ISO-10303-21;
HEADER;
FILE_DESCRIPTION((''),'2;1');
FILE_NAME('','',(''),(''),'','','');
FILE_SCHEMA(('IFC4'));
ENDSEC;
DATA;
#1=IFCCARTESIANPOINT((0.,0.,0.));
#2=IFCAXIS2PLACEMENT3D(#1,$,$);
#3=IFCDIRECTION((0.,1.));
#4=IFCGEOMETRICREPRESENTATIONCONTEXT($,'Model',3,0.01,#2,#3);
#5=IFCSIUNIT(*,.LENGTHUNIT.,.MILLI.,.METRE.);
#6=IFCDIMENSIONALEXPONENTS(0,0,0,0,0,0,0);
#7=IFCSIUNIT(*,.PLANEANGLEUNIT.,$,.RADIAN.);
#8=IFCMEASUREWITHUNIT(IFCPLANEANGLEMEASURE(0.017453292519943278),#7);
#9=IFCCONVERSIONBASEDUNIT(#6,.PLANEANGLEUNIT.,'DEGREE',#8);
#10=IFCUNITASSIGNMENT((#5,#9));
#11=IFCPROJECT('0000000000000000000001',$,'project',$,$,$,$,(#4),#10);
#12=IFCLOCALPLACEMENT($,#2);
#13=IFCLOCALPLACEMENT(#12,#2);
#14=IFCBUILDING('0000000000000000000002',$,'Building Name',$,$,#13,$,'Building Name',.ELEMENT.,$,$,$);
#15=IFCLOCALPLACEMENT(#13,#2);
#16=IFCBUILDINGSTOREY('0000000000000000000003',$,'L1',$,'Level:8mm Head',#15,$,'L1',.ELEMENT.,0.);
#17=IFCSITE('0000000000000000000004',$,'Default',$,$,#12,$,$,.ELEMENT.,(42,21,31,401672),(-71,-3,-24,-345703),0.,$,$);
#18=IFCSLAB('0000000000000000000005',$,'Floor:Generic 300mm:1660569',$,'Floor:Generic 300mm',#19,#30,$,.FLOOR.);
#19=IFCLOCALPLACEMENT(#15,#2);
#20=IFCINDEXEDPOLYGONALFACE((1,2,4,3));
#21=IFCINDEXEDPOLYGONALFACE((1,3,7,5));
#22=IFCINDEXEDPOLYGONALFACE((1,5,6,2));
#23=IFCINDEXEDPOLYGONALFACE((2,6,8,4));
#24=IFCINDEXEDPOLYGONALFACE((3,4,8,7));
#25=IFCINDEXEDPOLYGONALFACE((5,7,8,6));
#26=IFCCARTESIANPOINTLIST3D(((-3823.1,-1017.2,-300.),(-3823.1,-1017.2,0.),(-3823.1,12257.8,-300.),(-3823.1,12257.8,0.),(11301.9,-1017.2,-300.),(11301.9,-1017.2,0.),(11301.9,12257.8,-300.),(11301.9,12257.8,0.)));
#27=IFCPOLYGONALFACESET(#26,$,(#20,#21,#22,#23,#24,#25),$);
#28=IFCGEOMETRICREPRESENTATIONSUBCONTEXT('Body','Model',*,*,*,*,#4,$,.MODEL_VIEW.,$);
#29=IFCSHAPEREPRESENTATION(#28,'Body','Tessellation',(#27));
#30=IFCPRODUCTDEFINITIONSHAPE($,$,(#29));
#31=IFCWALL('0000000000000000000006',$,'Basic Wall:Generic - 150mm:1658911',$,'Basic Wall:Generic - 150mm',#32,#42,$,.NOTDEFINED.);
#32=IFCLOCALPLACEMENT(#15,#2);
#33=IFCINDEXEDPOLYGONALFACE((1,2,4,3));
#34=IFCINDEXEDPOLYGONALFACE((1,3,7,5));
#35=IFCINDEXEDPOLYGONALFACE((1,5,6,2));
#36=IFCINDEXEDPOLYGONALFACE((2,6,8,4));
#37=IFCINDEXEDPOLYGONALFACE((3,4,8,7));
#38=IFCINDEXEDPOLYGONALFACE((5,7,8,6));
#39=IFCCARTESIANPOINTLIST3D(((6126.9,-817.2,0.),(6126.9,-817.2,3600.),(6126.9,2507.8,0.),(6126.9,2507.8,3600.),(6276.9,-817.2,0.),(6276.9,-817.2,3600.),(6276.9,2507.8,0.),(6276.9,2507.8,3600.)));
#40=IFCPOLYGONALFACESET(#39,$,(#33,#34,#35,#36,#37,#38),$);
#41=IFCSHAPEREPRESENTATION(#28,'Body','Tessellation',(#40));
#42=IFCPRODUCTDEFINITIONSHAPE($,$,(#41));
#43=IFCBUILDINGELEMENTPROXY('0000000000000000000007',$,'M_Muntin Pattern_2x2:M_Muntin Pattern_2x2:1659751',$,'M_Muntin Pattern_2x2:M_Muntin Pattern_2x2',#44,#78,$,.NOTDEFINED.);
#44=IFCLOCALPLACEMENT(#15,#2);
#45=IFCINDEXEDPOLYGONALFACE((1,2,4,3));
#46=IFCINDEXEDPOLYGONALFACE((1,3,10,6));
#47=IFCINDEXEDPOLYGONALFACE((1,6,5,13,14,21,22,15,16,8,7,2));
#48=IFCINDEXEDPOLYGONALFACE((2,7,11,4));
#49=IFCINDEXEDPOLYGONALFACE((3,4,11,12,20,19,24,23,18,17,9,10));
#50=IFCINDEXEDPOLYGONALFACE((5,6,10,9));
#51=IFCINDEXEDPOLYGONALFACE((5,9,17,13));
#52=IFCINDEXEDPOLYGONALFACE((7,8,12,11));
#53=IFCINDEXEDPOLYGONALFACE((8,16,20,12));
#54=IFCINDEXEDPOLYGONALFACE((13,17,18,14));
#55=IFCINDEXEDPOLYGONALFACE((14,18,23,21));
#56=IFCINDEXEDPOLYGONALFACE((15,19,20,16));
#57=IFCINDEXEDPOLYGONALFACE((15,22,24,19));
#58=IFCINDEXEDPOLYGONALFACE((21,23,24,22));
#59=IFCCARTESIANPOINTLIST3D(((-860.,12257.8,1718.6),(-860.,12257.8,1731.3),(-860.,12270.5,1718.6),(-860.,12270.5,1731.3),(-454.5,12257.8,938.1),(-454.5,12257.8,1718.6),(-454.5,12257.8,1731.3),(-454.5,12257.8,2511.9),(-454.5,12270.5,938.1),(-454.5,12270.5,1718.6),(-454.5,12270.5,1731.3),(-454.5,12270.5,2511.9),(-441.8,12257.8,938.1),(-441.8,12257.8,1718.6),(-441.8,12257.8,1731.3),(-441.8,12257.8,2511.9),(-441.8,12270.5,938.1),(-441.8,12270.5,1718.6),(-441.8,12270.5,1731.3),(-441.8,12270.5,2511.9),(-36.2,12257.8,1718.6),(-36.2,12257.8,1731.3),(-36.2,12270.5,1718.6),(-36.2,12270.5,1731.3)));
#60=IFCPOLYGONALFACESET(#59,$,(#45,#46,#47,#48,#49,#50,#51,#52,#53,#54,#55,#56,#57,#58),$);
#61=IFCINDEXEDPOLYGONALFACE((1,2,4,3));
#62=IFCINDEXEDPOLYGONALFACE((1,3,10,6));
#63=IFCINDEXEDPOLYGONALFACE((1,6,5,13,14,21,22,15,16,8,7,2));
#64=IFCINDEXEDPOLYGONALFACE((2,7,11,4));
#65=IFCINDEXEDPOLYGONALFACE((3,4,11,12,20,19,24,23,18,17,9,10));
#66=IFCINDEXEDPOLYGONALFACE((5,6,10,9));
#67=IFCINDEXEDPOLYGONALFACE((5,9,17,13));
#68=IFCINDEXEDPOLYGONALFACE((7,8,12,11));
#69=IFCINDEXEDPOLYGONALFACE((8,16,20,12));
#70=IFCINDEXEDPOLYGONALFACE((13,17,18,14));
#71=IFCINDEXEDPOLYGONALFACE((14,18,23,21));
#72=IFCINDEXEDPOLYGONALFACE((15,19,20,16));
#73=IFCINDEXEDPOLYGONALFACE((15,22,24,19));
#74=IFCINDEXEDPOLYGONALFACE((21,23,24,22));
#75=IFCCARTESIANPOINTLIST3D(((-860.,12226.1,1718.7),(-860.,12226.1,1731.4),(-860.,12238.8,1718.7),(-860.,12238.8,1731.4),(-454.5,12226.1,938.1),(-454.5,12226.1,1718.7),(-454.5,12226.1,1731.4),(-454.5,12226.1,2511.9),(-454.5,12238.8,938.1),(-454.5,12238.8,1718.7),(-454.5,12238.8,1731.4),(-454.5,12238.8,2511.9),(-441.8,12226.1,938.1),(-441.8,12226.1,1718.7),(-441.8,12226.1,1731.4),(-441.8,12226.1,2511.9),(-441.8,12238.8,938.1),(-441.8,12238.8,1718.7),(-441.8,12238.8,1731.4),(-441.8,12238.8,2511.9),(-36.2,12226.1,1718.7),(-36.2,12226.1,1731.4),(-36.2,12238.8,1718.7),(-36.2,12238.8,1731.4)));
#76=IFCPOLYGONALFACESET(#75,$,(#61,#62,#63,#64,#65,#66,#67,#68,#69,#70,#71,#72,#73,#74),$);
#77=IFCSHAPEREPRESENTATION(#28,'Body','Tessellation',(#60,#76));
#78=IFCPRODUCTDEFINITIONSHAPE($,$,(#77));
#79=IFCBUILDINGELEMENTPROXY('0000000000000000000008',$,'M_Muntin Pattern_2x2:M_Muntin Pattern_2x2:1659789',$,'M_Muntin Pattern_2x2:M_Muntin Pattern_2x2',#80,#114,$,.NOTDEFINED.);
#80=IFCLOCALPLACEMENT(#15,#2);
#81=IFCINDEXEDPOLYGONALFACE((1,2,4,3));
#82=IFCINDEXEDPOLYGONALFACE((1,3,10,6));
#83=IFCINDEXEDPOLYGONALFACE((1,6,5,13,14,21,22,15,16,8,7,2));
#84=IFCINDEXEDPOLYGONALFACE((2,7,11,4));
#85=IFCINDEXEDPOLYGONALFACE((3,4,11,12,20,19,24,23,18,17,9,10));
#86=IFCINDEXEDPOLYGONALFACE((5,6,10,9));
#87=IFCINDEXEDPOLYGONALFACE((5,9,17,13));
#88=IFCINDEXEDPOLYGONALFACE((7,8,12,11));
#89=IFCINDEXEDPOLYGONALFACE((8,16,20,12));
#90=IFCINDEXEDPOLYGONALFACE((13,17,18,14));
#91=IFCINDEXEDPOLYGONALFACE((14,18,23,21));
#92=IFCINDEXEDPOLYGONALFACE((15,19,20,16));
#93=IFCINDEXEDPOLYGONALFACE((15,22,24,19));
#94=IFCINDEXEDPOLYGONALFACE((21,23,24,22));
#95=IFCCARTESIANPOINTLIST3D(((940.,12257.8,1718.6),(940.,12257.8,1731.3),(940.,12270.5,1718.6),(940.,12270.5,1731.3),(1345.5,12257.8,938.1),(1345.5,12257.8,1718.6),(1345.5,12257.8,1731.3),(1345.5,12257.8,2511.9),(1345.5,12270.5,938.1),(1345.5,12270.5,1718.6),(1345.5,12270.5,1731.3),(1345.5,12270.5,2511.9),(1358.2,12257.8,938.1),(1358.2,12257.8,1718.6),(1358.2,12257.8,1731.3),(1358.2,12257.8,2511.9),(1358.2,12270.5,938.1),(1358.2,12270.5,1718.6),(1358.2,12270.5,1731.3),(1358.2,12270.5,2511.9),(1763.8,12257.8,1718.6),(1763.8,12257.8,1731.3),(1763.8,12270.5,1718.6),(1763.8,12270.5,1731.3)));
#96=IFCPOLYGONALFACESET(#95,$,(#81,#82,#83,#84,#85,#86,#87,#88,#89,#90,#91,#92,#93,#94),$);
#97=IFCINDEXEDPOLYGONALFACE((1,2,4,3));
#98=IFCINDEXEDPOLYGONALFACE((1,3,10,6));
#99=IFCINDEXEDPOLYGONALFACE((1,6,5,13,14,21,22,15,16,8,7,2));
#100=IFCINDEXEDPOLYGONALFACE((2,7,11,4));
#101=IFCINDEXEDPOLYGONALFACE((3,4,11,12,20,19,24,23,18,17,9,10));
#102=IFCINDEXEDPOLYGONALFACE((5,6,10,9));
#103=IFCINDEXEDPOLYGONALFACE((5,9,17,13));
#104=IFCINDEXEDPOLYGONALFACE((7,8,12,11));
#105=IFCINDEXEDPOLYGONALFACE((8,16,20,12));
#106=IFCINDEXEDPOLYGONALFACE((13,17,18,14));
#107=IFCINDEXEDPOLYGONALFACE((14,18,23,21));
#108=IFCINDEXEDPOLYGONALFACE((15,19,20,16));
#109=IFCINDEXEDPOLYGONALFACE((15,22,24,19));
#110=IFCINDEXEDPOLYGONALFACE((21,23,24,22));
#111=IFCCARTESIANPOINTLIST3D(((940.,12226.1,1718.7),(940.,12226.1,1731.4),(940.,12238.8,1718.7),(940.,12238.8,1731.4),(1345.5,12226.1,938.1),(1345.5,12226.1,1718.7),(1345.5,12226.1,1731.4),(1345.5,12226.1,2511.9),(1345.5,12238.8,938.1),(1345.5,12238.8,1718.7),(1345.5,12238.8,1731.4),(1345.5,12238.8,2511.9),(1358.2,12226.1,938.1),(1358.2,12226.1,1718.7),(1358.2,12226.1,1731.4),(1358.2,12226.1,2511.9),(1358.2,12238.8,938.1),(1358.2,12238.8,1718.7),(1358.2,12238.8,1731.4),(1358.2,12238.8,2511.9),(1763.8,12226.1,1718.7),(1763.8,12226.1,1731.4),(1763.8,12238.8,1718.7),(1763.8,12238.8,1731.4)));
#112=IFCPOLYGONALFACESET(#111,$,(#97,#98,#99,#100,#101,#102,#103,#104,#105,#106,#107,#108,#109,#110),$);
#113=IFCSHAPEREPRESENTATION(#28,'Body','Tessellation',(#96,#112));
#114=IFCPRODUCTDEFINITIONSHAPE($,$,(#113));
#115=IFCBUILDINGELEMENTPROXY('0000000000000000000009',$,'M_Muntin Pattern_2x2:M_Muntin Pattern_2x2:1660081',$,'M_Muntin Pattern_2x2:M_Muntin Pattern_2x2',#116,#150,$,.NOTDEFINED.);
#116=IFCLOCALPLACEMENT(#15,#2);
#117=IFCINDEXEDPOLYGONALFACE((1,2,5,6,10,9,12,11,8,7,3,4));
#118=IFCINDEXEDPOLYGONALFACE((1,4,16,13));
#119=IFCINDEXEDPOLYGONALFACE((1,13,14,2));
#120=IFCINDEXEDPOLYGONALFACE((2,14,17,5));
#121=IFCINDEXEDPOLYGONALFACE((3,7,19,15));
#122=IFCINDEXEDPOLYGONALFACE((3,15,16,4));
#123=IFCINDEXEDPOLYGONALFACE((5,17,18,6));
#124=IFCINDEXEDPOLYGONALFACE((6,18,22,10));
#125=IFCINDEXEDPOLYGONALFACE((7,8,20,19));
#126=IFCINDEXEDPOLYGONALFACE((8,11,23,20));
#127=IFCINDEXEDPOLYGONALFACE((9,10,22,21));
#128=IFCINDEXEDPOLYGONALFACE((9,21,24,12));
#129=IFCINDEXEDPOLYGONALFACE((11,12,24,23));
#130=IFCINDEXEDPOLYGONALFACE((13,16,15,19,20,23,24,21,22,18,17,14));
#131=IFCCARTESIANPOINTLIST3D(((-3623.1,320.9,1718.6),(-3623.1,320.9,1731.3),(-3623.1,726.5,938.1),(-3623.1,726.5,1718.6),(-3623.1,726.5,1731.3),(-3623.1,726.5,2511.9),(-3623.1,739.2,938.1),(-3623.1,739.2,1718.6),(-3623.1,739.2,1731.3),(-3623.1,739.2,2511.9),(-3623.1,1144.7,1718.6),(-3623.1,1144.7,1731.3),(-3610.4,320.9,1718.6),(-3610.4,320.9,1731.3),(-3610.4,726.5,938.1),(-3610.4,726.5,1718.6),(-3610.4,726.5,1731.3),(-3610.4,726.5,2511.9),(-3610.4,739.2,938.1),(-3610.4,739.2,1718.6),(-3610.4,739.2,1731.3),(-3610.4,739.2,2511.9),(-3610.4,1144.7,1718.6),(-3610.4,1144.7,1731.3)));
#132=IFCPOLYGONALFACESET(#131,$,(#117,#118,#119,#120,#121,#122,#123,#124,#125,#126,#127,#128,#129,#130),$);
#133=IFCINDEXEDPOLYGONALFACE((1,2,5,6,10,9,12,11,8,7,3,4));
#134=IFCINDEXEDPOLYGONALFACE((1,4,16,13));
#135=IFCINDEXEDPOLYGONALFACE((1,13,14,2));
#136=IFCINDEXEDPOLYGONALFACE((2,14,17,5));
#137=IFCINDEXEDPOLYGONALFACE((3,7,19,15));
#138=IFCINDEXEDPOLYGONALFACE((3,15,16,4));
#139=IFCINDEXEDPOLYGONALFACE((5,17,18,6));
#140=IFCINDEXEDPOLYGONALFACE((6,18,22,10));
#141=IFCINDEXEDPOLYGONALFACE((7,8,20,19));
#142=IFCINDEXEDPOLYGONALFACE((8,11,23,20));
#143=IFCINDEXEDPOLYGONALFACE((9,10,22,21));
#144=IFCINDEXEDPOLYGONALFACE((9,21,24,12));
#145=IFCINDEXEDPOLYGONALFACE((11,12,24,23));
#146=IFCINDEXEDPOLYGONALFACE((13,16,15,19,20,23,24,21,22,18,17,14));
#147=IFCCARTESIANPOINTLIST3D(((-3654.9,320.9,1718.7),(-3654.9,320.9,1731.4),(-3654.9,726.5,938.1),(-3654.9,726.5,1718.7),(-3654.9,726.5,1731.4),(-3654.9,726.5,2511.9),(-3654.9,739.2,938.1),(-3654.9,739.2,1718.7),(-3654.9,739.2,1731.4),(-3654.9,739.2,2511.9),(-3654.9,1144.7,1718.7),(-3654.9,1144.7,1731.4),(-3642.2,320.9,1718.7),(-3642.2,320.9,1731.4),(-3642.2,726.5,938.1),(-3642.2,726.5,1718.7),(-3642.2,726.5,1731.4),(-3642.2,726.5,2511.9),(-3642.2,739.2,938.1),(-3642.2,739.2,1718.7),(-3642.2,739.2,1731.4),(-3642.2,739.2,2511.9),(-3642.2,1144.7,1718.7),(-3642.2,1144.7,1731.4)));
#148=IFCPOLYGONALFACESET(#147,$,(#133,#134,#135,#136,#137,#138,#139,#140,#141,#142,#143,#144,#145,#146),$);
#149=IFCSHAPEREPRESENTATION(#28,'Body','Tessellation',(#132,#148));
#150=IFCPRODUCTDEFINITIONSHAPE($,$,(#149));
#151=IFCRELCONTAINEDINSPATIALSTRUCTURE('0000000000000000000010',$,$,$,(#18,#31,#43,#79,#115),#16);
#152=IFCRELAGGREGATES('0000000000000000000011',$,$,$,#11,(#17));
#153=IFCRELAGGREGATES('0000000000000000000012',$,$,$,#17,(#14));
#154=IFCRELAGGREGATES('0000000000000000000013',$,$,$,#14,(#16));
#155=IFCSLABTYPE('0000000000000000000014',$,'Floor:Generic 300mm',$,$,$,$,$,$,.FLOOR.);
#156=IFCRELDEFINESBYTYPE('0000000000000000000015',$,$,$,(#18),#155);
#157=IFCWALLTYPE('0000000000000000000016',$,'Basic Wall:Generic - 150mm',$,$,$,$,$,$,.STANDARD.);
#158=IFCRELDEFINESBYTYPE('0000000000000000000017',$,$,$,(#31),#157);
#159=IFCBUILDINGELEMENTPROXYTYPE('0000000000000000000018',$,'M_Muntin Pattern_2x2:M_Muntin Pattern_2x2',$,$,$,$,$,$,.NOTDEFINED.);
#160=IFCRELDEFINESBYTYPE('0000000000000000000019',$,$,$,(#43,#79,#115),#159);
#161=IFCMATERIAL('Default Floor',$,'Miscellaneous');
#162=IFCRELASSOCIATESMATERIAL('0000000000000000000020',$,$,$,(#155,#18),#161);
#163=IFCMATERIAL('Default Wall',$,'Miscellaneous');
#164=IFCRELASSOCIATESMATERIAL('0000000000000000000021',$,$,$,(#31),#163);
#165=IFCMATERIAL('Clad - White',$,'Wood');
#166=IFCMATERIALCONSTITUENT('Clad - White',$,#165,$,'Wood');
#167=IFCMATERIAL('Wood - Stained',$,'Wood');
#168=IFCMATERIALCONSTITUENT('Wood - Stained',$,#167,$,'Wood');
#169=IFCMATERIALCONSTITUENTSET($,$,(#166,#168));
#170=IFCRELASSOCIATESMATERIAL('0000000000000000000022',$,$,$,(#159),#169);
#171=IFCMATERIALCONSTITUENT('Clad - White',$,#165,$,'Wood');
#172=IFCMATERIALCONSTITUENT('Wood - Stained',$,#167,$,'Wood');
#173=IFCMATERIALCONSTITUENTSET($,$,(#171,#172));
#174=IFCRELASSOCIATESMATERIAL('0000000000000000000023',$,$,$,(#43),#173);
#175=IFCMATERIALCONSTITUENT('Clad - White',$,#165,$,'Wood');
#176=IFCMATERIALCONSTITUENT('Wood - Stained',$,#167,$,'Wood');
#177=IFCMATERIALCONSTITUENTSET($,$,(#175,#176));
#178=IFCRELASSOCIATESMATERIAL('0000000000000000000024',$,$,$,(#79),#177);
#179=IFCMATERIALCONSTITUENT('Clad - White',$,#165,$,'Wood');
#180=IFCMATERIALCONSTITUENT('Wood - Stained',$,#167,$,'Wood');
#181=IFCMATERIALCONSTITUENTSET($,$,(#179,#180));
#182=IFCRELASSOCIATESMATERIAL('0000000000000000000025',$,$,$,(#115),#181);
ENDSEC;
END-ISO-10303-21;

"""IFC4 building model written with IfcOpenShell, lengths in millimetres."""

from ifc_helpers import new_model, entity, si_unit, converted_unit, direction, frame, origin, place, context, subcontext, project, spatial, indexed_curve, outline, extrude, source, transform, mapped, material, constituent, constituent_set, type_object, type_shapes, element, save


model = new_model("IFC4")

# Units and contexts
model_context = context("Model", 3, precision=0.01, world=origin(), true_north=direction((0.0, 1.0)))
body_context = subcontext(model_context, "Body", "Model", "MODEL_VIEW")
ifc_project = project(units=[si_unit("LENGTHUNIT", "METRE", prefix="MILLI"), converted_unit("PLANEANGLEUNIT", "DEGREE", entity("IfcPlaneAngleMeasure", 0.017453292519943278), si_unit("PLANEANGLEUNIT", "RADIAN"), dimensions=[0, 0, 0, 0, 0, 0, 0])], contexts=[model_context])

# Site, building, storey
site_placement = place(None, origin())
site = spatial("IfcSite", under=ifc_project, at=site_placement, Name="Default", CompositionType="ELEMENT", RefLatitude=(42, 21, 31, 401672), RefLongitude=(-71, -3, -24, -345703), RefElevation=0.0)
building_placement = place(site_placement, origin())
building = spatial("IfcBuilding", under=site, at=building_placement, Name="Building Name", LongName="Building Name", CompositionType="ELEMENT")
storey_placement = place(building_placement, origin())
storey = spatial("IfcBuildingStorey", under=building, at=storey_placement, Name="L1", ObjectType="Level:8mm Head", LongName="L1", CompositionType="ELEMENT", Elevation=0.0)

# Slab
ifc_material_1 = material(Name="Default Floor", Category="Miscellaneous")
slab_type = type_object("IfcSlabType", Name="Floor:Generic 300mm", PredefinedType="FLOOR", material=ifc_material_1)
slab_placement = place(storey_placement, origin())
element("IfcSlab", 1, at=slab_placement, inside=storey, type_object=slab_type, material=ifc_material_1, Name="Floor:Generic 300mm:1660569", ObjectType="Floor:Generic 300mm", PredefinedType="FLOOR", context=body_context, shape_type="SweptSolid", body=[
    extrude(outline(indexed_curve([(-6637.5, -7562.5), (6637.5, -7562.5), (6637.5, 7562.5), (-6637.5, 7562.5), (-6637.5, -7562.5)], self_intersect=False)), frame((3739.4, 5620.3, 0.0), z_axis=(0.0, 0.0, -1.0), x_axis=(0.0, 1.0, 0.0)), (0.0, 0.0, 1.0), 300.0),
])

# Wall
ifc_material_2 = material(Name="Default Wall", Category="Miscellaneous")
wall_type = type_object("IfcWallType", Name="Basic Wall:Generic - 150mm", PredefinedType="STANDARD")
wall_placement = place(storey_placement, frame((6201.9, 2507.8, 0.0), z_axis=(0.0, 0.0, 1.0), x_axis=(0.0, -1.0, 0.0)))
element("IfcWall", 2, at=wall_placement, inside=storey, type_object=wall_type, material=ifc_material_2, Name="Basic Wall:Generic - 150mm:1658911", ObjectType="Basic Wall:Generic - 150mm", PredefinedType="NOTDEFINED", context=body_context, shape_type="SweptSolid", body=[
    extrude(outline(indexed_curve([(3325.0, 75.0), (0.0, 75.0), (0.0, -75.0), (3325.0, -75.0), (3325.0, 75.0)], self_intersect=False)), origin(), (0.0, 0.0, 1.0), 3600.0),
])

# Building element proxies
ifc_material_3 = material(Name="Clad - White", Category="Wood")
ifc_constituent_1 = constituent(ifc_material_3, Name="Clad - White", Category="Wood")
ifc_material_4 = material(Name="Wood - Stained", Category="Wood")
ifc_constituent_2 = constituent(ifc_material_4, Name="Wood - Stained", Category="Wood")
ifc_constituent_set_1 = constituent_set(constituents=[ifc_constituent_1, ifc_constituent_2])
ifc_constituent_3 = constituent(ifc_material_3, Name="Clad - White", Category="Wood")
ifc_constituent_4 = constituent(ifc_material_4, Name="Wood - Stained", Category="Wood")
ifc_constituent_set_2 = constituent_set(constituents=[ifc_constituent_3, ifc_constituent_4])
building_element_proxy_type_1 = type_object("IfcBuildingElementProxyType", Name="M_Muntin Pattern_2x2:M_Muntin Pattern_2x2", PredefinedType="NOTDEFINED", material=ifc_constituent_set_2)
shared_shape_1 = source(origin(), body_context, "Body", "SweptSolid", [
    extrude(outline(indexed_curve([(6.4, -6.4), (786.9, -6.4), (786.9, 6.3), (6.4, 6.3), (6.4, 411.9), (-6.3, 411.9), (-6.3, 6.3), (-786.9, 6.3), (-786.9, -6.4), (-6.3, -6.4), (-6.3, -411.9), (6.4, -411.9), (6.4, -6.4)], self_intersect=False)), frame((0.0, -22.2, 786.9), z_axis=(0.0, 1.0, 0.0), x_axis=(0.0, 0.0, 1.0)), (0.0, 0.0, 1.0), 12.7),
    extrude(outline(indexed_curve([(6.4, -6.4), (786.9, -6.4), (786.9, 6.3), (6.4, 6.3), (6.4, 411.9), (-6.3, 411.9), (-6.3, 6.3), (-786.9, 6.3), (-786.9, -6.4), (-6.3, -6.4), (-6.3, -411.9), (6.4, -411.9), (6.4, -6.4)], self_intersect=False)), frame((0.0, 9.5, 786.9), z_axis=(0.0, 1.0, 0.0), x_axis=(0.0, 0.0, 1.0)), (0.0, 0.0, 1.0), 12.7),
])
type_shapes(building_element_proxy_type_1, [shared_shape_1])
proxy_1_placement = place(storey_placement, frame((-448.1, 12248.3, 938.1), z_axis=(0.0, 0.0, 1.0), x_axis=(-1.0, 0.0, 0.0)))
element("IfcBuildingElementProxy", 3, at=proxy_1_placement, inside=storey, type_object=building_element_proxy_type_1, material=ifc_constituent_set_1, Name="M_Muntin Pattern_2x2:M_Muntin Pattern_2x2:1659751", ObjectType="M_Muntin Pattern_2x2:M_Muntin Pattern_2x2", PredefinedType="NOTDEFINED", context=body_context, shape_type="MappedRepresentation", body=[
    mapped(shared_shape_1, transform((0.0, 0.0, 0.0), scale=1.0)),
])
ifc_constituent_5 = constituent(ifc_material_3, Name="Clad - White", Category="Wood")
ifc_constituent_6 = constituent(ifc_material_4, Name="Wood - Stained", Category="Wood")
ifc_constituent_set_3 = constituent_set(constituents=[ifc_constituent_5, ifc_constituent_6])
proxy_2_placement = place(storey_placement, frame((1351.9, 12248.3, 938.1), z_axis=(0.0, 0.0, 1.0), x_axis=(-1.0, 0.0, 0.0)))
element("IfcBuildingElementProxy", 4, at=proxy_2_placement, inside=storey, type_object=building_element_proxy_type_1, material=ifc_constituent_set_3, Name="M_Muntin Pattern_2x2:M_Muntin Pattern_2x2:1659789", ObjectType="M_Muntin Pattern_2x2:M_Muntin Pattern_2x2", PredefinedType="NOTDEFINED", context=body_context, shape_type="MappedRepresentation", body=[
    mapped(shared_shape_1, transform((0.0, 0.0, 0.0), scale=1.0)),
])
ifc_constituent_7 = constituent(ifc_material_3, Name="Clad - White", Category="Wood")
ifc_constituent_8 = constituent(ifc_material_4, Name="Wood - Stained", Category="Wood")
ifc_constituent_set_4 = constituent_set(constituents=[ifc_constituent_7, ifc_constituent_8])
proxy_3_placement = place(storey_placement, frame((-3632.6, 732.8, 938.1), z_axis=(0.0, 0.0, 1.0), x_axis=(0.0, 1.0, 0.0)))
element("IfcBuildingElementProxy", 5, at=proxy_3_placement, inside=storey, type_object=building_element_proxy_type_1, material=ifc_constituent_set_4, Name="M_Muntin Pattern_2x2:M_Muntin Pattern_2x2:1660081", ObjectType="M_Muntin Pattern_2x2:M_Muntin Pattern_2x2", PredefinedType="NOTDEFINED", context=body_context, shape_type="MappedRepresentation", body=[
    mapped(shared_shape_1, transform((0.0, 0.0, 0.0), scale=1.0)),
])

save(model, "model.ifc")
